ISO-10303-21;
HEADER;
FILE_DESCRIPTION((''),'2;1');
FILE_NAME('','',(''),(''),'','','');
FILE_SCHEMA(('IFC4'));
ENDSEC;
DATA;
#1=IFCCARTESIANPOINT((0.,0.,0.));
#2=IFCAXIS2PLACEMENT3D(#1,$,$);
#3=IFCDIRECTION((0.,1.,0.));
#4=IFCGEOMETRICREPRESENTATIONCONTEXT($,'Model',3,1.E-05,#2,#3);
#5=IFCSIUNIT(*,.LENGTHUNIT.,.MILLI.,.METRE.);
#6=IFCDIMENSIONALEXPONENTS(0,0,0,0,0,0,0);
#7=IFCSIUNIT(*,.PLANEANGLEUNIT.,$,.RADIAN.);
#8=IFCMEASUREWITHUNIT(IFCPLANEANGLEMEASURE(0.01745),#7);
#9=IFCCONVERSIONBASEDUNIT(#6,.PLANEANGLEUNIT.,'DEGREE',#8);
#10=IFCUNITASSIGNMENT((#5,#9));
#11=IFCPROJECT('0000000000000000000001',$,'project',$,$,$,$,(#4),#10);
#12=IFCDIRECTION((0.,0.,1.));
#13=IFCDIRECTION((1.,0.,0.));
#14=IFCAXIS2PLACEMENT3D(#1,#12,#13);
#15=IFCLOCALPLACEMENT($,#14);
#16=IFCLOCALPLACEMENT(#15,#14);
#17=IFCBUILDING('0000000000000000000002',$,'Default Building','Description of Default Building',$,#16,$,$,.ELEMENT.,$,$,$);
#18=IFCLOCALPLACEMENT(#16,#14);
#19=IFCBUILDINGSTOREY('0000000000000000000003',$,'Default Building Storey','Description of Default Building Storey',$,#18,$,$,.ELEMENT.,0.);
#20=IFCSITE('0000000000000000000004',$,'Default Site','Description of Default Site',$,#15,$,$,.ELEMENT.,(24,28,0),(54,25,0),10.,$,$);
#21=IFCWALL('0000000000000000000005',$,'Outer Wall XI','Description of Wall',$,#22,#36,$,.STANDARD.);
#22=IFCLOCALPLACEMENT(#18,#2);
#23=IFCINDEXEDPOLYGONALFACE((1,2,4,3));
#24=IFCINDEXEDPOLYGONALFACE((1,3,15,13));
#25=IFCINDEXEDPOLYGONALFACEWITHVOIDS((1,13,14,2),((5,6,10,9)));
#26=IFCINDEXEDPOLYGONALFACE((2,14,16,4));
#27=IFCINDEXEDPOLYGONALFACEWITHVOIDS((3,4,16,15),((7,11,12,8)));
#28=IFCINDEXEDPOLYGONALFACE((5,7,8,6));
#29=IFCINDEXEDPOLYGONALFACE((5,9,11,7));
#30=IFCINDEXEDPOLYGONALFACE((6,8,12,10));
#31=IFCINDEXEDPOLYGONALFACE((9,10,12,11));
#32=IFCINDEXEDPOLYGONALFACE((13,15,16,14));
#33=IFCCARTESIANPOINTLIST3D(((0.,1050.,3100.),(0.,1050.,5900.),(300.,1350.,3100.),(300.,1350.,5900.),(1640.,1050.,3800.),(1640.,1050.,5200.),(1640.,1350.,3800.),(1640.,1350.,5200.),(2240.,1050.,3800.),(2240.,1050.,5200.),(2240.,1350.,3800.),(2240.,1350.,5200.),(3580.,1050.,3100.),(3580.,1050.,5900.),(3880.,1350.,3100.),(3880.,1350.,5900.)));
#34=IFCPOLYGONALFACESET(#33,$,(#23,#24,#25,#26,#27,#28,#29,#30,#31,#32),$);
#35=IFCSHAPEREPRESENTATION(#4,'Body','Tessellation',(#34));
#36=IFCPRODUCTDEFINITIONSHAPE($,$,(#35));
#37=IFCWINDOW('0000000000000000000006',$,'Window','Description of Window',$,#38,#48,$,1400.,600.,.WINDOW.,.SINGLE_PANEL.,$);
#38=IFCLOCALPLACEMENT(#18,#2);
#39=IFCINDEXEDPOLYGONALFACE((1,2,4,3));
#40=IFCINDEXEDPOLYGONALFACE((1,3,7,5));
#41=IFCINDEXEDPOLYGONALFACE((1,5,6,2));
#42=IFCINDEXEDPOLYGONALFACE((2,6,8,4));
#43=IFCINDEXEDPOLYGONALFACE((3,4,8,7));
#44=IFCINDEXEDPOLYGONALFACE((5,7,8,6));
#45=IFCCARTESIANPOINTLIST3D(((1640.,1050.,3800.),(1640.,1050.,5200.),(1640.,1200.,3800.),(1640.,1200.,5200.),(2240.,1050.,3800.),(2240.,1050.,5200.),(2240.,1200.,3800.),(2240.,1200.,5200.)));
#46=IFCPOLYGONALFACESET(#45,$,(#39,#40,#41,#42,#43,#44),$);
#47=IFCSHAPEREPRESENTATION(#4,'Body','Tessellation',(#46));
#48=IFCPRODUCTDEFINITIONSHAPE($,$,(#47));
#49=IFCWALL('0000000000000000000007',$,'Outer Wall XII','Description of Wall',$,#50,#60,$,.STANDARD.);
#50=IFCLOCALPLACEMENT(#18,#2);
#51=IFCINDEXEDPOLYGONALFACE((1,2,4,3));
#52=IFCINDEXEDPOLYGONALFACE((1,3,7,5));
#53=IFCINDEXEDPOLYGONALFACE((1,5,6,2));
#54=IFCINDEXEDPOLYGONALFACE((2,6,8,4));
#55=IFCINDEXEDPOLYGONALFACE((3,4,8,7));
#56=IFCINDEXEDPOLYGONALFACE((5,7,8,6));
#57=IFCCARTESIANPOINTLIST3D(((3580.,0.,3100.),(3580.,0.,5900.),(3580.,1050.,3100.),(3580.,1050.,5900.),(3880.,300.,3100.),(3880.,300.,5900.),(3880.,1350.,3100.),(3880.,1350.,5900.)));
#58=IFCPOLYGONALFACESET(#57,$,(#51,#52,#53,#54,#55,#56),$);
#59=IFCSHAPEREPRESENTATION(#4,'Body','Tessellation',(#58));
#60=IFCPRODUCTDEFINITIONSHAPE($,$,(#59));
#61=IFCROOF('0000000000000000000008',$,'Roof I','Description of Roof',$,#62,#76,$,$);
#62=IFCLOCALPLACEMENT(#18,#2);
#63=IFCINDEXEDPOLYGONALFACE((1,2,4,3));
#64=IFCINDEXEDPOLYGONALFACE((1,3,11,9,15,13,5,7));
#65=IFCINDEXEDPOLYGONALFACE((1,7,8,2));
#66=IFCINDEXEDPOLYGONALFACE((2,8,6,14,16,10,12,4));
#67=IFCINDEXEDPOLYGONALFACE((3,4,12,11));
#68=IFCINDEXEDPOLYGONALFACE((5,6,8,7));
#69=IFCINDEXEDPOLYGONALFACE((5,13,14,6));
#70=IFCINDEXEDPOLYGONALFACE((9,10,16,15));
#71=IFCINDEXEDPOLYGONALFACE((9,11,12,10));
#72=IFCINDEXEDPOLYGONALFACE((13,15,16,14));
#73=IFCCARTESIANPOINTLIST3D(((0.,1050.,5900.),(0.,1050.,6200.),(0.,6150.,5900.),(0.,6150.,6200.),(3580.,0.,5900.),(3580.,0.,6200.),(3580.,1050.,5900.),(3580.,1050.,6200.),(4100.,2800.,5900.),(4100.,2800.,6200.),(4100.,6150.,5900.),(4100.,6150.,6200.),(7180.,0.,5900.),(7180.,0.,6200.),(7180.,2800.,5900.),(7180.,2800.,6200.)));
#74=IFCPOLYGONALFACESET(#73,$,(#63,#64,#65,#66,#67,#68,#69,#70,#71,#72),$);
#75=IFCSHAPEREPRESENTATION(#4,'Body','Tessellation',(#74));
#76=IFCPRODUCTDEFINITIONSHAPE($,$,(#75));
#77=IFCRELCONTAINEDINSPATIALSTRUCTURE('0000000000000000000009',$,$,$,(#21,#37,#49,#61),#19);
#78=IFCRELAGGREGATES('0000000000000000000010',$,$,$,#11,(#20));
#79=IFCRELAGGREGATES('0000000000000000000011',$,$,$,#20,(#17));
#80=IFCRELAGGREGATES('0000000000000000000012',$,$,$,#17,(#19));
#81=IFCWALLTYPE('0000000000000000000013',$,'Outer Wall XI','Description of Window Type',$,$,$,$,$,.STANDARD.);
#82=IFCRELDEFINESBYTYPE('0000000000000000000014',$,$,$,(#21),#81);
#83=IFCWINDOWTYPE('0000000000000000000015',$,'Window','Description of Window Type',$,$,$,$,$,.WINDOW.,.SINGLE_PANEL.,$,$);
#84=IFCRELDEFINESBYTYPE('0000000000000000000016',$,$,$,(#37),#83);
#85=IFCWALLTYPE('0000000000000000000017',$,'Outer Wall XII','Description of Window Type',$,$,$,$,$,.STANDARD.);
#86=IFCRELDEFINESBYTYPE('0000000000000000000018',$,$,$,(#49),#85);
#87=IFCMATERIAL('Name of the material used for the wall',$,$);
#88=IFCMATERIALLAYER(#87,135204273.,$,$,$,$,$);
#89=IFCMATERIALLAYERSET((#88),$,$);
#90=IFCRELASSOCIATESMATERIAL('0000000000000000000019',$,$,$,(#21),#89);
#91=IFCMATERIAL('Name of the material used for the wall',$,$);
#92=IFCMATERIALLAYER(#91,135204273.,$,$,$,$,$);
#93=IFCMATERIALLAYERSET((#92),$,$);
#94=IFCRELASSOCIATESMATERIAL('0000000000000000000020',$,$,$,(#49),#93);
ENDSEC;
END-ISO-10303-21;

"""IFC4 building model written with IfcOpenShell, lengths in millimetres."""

from ifc_helpers import new_model, entity, si_unit, converted_unit, direction, frame, origin, origin_with_axes, place, context, project, spatial, polyline, outline, extrude, material, layer, layer_set, layer_usage, type_object, element, fill, save


model = new_model("IFC4")

# Units and contexts
model_context = context("Model", 3, precision=1e-05, world=origin(), true_north=direction((0.0, 1.0, 0.0)))
ifc_project = project(units=[si_unit("LENGTHUNIT", "METRE", prefix="MILLI"), converted_unit("PLANEANGLEUNIT", "DEGREE", entity("IfcPlaneAngleMeasure", 0.01745), si_unit("PLANEANGLEUNIT", "RADIAN"), dimensions=[0, 0, 0, 0, 0, 0, 0])], contexts=[model_context])

# Site, building, storey
site_placement = place(None, origin_with_axes())
site = spatial("IfcSite", under=ifc_project, at=site_placement, Name="Default Site", Description="Description of Default Site", CompositionType="ELEMENT", RefLatitude=(24, 28, 0), RefLongitude=(54, 25, 0), RefElevation=10.0)
building_placement = place(site_placement, origin_with_axes())
building = spatial("IfcBuilding", under=site, at=building_placement, Name="Default Building", Description="Description of Default Building", CompositionType="ELEMENT")
storey_placement = place(building_placement, origin_with_axes())
storey = spatial("IfcBuildingStorey", under=building, at=storey_placement, Name="Default Building Storey", Description="Description of Default Building Storey", CompositionType="ELEMENT", Elevation=0.0)

# Wall, opening, window
ifc_material_1 = material(Name="Name of the material used for the wall")
ifc_layer_1 = layer(ifc_material_1, 135204273.0)
ifc_layer_set_1 = layer_set([ifc_layer_1])
ifc_layer_usage_1 = layer_usage(ifc_layer_set_1, "AXIS2", "POSITIVE", -67602136.5)
wall_type_1 = type_object("IfcWallType", Name="Outer Wall XI", Description="Description of Window Type", PredefinedType="STANDARD")
wall_1_placement = place(storey_placement, frame((150.0, 1200.0, 3100.0), z_axis=(0.0, 0.0, 1.0), x_axis=(1.0, 0.0, 0.0)))
wall_1 = element("IfcWall", 1, at=wall_1_placement, inside=storey, type_object=wall_type_1, material=ifc_layer_usage_1, Name="Outer Wall XI", Description="Description of Wall", PredefinedType="STANDARD", context=model_context, shape_type="SweptSolid", body=[
    extrude(outline(polyline([(-150.0, -150.0), (150.0, 150.0), (3730.0, 150.0), (3430.0, -150.0), (-150.0, -150.0)])), origin_with_axes(), (0.0, 0.0, 1.0), 2800.0),
])
opening_1_placement = place(wall_1_placement, frame((1490.0, -150.0, 700.0), z_axis=(0.0, 0.0, 1.0), x_axis=(1.0, 0.0, 0.0)))
opening_1 = element("IfcOpeningElement", 2, at=opening_1_placement, cuts=wall_1, context=model_context, shape_type="SweptSolid", body=[
    extrude(outline(polyline([(0.0, 0.0), (0.0, 300.0), (600.0, 300.0), (600.0, 0.0), (0.0, 0.0)])), origin_with_axes(), (0.0, 0.0, 1.0), 1400.0),
])
window_type_1 = type_object("IfcWindowType", Name="Window", Description="Description of Window Type", PartitioningType="SINGLE_PANEL", PredefinedType="WINDOW")
window_1_placement = place(opening_1_placement, origin_with_axes())
window_1 = element("IfcWindow", 3, at=window_1_placement, inside=storey, type_object=window_type_1, Name="Window", Description="Description of Window", OverallHeight=1400.0, OverallWidth=600.0, PartitioningType="SINGLE_PANEL", PredefinedType="WINDOW", context=model_context, shape_type="SweptSolid", body=[
    extrude(outline(polyline([(0.0, 0.0), (0.0, 150.0), (600.0, 150.0), (600.0, 0.0), (0.0, 0.0)])), origin_with_axes(), (0.0, 0.0, 1.0), 1400.0),
])
fill(opening_1, window_1)

# Wall
ifc_material_2 = material(Name="Name of the material used for the wall")
ifc_layer_2 = layer(ifc_material_2, 135204273.0)
ifc_layer_set_2 = layer_set([ifc_layer_2])
ifc_layer_usage_2 = layer_usage(ifc_layer_set_2, "AXIS2", "POSITIVE", -67602136.5)
wall_type_2 = type_object("IfcWallType", Name="Outer Wall XII", Description="Description of Window Type", PredefinedType="STANDARD")
wall_2_placement = place(storey_placement, frame((3730.0, 1200.0, 3100.0), z_axis=(0.0, 0.0, 1.0), x_axis=(0.0, -1.0, 0.0)))
element("IfcWall", 4, at=wall_2_placement, inside=storey, type_object=wall_type_2, material=ifc_layer_usage_2, Name="Outer Wall XII", Description="Description of Wall", PredefinedType="STANDARD", context=model_context, shape_type="SweptSolid", body=[
    extrude(outline(polyline([(150.0, -150.0), (-150.0, 150.0), (900.0, 150.0), (1200.0, -150.0), (150.0, -150.0)])), origin_with_axes(), (0.0, 0.0, 1.0), 2800.0),
])

# Roof
roof_placement = place(storey_placement, frame((0.0, 0.0, 5900.0), z_axis=(0.0, 0.0, 1.0), x_axis=(1.0, 0.0, 0.0)))
element("IfcRoof", 5, at=roof_placement, inside=storey, Name="Roof I", Description="Description of Roof", context=model_context, shape_type="SweptSolid", body=[
    extrude(outline(polyline([(0.0, 1050.0), (0.0, 6150.0), (4100.0, 6150.0), (4100.0, 2800.0), (7180.0, 2800.0), (7180.0, 0.0), (3580.0, 0.0), (3580.0, 1050.0), (0.0, 1050.0)])), origin_with_axes(), (0.0, 0.0, 1.0), 300.0),
])

save(model, "model.ifc")
